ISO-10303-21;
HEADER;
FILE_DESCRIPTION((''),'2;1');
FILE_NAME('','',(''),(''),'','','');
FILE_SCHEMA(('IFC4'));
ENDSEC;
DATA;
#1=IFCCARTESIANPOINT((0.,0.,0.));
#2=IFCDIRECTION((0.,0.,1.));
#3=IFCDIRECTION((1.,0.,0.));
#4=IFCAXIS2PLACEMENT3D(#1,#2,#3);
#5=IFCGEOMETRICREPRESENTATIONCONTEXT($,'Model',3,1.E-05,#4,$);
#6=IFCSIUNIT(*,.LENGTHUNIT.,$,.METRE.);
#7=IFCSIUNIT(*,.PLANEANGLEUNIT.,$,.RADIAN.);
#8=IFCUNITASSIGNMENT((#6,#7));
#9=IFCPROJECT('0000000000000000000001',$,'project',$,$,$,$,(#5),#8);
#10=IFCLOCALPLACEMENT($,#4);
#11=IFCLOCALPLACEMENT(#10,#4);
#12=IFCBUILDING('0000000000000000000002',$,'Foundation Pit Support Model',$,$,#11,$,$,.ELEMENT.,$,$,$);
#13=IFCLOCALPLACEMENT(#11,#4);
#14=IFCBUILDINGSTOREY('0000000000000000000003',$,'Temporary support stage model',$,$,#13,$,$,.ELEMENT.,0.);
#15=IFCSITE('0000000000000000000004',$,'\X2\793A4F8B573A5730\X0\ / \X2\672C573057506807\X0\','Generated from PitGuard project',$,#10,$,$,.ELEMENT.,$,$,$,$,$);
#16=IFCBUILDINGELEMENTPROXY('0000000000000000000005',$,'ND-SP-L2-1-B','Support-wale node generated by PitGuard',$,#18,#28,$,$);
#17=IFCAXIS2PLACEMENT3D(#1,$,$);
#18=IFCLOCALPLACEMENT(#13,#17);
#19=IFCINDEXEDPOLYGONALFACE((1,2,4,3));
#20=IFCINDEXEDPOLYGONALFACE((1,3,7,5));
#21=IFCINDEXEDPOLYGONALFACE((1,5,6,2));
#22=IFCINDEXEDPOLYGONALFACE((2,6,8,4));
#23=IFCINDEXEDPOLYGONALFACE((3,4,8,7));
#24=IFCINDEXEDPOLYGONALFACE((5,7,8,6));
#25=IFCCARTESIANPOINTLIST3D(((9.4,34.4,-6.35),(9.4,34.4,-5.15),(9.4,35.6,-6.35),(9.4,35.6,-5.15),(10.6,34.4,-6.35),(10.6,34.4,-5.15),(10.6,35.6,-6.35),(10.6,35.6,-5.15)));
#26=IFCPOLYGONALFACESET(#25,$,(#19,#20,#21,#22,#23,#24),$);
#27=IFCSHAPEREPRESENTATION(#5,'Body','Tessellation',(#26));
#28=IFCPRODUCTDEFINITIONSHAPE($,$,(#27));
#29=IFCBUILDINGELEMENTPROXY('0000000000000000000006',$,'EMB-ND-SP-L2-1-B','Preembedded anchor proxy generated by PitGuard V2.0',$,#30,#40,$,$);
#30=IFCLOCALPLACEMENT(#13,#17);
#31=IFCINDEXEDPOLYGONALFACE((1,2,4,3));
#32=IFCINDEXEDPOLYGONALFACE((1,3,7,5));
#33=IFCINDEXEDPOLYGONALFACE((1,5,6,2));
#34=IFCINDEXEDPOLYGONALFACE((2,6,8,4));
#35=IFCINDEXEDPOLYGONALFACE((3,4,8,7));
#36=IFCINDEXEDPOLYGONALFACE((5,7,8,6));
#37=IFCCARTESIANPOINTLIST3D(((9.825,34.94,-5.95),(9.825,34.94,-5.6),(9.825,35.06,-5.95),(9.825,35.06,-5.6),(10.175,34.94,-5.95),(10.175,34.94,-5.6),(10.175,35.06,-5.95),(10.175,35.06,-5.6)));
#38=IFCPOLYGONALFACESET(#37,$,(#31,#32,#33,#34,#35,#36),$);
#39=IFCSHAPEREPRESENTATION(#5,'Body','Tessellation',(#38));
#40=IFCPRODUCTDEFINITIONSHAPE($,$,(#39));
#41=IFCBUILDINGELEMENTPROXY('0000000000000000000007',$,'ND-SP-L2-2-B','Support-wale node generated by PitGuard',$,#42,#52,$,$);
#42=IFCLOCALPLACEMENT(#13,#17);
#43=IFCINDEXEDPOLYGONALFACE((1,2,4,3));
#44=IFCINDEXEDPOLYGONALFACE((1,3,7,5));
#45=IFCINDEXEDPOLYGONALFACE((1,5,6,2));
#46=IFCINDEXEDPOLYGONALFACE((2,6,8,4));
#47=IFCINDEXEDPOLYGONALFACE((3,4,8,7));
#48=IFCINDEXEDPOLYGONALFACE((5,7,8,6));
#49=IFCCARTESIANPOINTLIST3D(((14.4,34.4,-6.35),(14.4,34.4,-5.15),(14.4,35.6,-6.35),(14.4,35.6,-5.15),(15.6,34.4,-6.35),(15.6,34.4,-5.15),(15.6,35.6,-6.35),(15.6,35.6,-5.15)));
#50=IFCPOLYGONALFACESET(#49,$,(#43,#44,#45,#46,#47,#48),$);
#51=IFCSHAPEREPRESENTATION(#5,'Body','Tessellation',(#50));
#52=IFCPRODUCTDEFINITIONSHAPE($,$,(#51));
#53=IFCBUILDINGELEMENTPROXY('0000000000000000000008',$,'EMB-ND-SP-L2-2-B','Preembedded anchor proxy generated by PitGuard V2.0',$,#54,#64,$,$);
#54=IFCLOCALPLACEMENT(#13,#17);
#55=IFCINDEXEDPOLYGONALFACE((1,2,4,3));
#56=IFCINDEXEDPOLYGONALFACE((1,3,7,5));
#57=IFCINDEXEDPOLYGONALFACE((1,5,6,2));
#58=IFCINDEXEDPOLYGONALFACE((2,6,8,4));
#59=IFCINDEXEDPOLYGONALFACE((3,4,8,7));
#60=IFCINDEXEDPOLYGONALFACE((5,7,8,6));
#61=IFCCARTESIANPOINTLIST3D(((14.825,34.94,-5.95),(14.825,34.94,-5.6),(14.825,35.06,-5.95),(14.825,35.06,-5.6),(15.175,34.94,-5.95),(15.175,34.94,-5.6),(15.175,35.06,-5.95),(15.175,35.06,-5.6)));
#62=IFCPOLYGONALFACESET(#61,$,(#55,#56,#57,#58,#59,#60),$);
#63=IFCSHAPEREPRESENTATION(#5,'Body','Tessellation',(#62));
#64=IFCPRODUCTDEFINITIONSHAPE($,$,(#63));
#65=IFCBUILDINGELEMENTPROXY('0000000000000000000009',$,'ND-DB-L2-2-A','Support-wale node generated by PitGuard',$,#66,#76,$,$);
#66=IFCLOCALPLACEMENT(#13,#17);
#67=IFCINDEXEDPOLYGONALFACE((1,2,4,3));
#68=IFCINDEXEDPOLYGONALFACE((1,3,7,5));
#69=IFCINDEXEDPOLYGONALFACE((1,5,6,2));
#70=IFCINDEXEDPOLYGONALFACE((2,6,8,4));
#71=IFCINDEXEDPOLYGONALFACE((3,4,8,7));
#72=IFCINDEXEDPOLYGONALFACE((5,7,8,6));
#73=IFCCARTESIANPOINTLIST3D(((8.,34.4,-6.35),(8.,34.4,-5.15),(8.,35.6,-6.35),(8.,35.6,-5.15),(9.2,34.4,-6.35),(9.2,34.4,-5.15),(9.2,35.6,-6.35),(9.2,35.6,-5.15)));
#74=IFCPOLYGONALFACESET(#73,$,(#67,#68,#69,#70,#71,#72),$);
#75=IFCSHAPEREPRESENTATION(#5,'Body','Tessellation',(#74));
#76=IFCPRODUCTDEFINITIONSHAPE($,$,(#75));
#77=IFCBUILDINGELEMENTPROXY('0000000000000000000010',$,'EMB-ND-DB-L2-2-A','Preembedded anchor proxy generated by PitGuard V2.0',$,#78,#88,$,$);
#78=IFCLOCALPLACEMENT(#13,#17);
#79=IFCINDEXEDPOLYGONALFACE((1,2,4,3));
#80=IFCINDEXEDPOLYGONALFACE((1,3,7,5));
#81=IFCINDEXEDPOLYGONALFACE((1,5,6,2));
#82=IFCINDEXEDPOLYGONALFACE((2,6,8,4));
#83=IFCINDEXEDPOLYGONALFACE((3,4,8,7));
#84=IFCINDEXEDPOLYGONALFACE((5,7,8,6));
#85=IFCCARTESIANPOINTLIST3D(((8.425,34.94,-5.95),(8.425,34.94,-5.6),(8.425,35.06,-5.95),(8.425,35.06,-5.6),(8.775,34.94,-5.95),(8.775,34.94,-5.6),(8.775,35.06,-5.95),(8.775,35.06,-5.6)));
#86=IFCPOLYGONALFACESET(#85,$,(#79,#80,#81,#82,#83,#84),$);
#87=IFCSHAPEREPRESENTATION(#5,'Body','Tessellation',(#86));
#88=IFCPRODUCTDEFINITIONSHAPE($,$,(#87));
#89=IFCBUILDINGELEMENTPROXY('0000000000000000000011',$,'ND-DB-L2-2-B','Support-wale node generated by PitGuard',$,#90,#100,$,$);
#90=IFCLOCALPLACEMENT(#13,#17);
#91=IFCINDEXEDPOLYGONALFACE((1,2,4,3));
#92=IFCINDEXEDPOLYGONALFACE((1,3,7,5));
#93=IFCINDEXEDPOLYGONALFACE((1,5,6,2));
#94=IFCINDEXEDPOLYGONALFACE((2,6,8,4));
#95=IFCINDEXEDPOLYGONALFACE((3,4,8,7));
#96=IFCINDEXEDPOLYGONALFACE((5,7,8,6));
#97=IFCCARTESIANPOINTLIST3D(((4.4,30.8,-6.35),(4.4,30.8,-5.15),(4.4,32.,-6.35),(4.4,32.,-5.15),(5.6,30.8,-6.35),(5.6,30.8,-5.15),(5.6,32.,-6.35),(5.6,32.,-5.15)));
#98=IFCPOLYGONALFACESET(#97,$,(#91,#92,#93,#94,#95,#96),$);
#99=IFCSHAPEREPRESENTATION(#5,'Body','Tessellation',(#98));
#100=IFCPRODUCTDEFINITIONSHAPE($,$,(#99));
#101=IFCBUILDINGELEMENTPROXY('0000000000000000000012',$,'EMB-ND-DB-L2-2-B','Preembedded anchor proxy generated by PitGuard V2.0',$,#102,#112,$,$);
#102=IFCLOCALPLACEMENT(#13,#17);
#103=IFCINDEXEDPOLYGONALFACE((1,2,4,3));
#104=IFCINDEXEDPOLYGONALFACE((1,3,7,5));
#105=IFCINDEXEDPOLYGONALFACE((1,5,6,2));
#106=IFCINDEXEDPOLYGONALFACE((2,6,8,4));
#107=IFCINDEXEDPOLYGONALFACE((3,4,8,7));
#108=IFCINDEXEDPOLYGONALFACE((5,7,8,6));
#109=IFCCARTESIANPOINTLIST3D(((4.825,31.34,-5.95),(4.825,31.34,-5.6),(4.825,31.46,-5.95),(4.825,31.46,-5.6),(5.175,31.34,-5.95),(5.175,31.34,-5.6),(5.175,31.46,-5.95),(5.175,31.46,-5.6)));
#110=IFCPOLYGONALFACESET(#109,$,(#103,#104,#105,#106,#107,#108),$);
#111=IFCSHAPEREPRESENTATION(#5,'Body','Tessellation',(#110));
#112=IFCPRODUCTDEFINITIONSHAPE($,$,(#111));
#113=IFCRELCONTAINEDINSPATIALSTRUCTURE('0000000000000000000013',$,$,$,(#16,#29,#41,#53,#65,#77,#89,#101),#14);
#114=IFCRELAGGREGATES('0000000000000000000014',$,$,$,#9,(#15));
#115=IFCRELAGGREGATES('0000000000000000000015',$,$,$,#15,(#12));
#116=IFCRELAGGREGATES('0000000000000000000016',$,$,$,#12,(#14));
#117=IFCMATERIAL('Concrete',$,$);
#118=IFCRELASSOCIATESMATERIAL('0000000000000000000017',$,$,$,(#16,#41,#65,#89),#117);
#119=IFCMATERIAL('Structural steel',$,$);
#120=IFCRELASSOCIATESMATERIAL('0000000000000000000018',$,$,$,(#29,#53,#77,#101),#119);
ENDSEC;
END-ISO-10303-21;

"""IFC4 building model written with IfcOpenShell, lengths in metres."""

from ifc_helpers import new_model, si_unit, frame, origin_with_axes, origin_2d, place, context, project, spatial, rectangle, extrude, material, element, save


model = new_model("IFC4")

# Units and contexts
model_context = context("Model", 3, precision=1e-05, world=origin_with_axes())
ifc_project = project(units=[si_unit("LENGTHUNIT", "METRE"), si_unit("PLANEANGLEUNIT", "RADIAN")], contexts=[model_context])

# Site, building, storey
site_placement = place(None, origin_with_axes())
site = spatial("IfcSite", under=ifc_project, at=site_placement, Name="示例场地 / 本地坐标", Description="Generated from PitGuard project", CompositionType="ELEMENT")
building_placement = place(site_placement, origin_with_axes())
building = spatial("IfcBuilding", under=site, at=building_placement, Name="Foundation Pit Support Model", CompositionType="ELEMENT")
storey_placement = place(building_placement, origin_with_axes())
storey = spatial("IfcBuildingStorey", under=building, at=storey_placement, Name="Temporary support stage model", CompositionType="ELEMENT", Elevation=0.0)

# Shared definitions
ifc_material_1 = material(Name="Concrete")

# Shared definitions
ifc_material_2 = material(Name="Structural steel")

# Building element proxies
proxy_1_placement = place(storey_placement, frame((10.0, 35.0, -6.35), z_axis=(0.0, 0.0, 1.0), x_axis=(1.0, 0.0, 0.0)))
element("IfcBuildingElementProxy", 1, at=proxy_1_placement, inside=storey, material=ifc_material_1, Name="ND-SP-L2-1-B", Description="Support-wale node generated by PitGuard", context=model_context, shape_type="SweptSolid", body=[
    extrude(rectangle(XDim=1.2, YDim=1.2, at=origin_2d()), origin_with_axes(), (0.0, 0.0, 1.0), 1.2),
])
proxy_2_placement = place(storey_placement, frame((10.0, 35.0, -5.95), z_axis=(0.0, 0.0, 1.0), x_axis=(1.0, 0.0, 0.0)))
element("IfcBuildingElementProxy", 2, at=proxy_2_placement, inside=storey, material=ifc_material_2, Name="EMB-ND-SP-L2-1-B", Description="Preembedded anchor proxy generated by PitGuard V2.0", context=model_context, shape_type="SweptSolid", body=[
    extrude(rectangle(XDim=0.35, YDim=0.12, at=origin_2d()), origin_with_axes(), (0.0, 0.0, 1.0), 0.35),
])
proxy_3_placement = place(storey_placement, frame((15.0, 35.0, -6.35), z_axis=(0.0, 0.0, 1.0), x_axis=(1.0, 0.0, 0.0)))
element("IfcBuildingElementProxy", 3, at=proxy_3_placement, inside=storey, material=ifc_material_1, Name="ND-SP-L2-2-B", Description="Support-wale node generated by PitGuard", context=model_context, shape_type="SweptSolid", body=[
    extrude(rectangle(XDim=1.2, YDim=1.2, at=origin_2d()), origin_with_axes(), (0.0, 0.0, 1.0), 1.2),
])
proxy_4_placement = place(storey_placement, frame((15.0, 35.0, -5.95), z_axis=(0.0, 0.0, 1.0), x_axis=(1.0, 0.0, 0.0)))
element("IfcBuildingElementProxy", 4, at=proxy_4_placement, inside=storey, material=ifc_material_2, Name="EMB-ND-SP-L2-2-B", Description="Preembedded anchor proxy generated by PitGuard V2.0", context=model_context, shape_type="SweptSolid", body=[
    extrude(rectangle(XDim=0.35, YDim=0.12, at=origin_2d()), origin_with_axes(), (0.0, 0.0, 1.0), 0.35),
])
proxy_5_placement = place(storey_placement, frame((8.6, 35.0, -6.35), z_axis=(0.0, 0.0, 1.0), x_axis=(1.0, 0.0, 0.0)))
element("IfcBuildingElementProxy", 5, at=proxy_5_placement, inside=storey, material=ifc_material_1, Name="ND-DB-L2-2-A", Description="Support-wale node generated by PitGuard", context=model_context, shape_type="SweptSolid", body=[
    extrude(rectangle(XDim=1.2, YDim=1.2, at=origin_2d()), origin_with_axes(), (0.0, 0.0, 1.0), 1.2),
])
proxy_6_placement = place(storey_placement, frame((8.6, 35.0, -5.95), z_axis=(0.0, 0.0, 1.0), x_axis=(1.0, 0.0, 0.0)))
element("IfcBuildingElementProxy", 6, at=proxy_6_placement, inside=storey, material=ifc_material_2, Name="EMB-ND-DB-L2-2-A", Description="Preembedded anchor proxy generated by PitGuard V2.0", context=model_context, shape_type="SweptSolid", body=[
    extrude(rectangle(XDim=0.35, YDim=0.12, at=origin_2d()), origin_with_axes(), (0.0, 0.0, 1.0), 0.35),
])
proxy_7_placement = place(storey_placement, frame((5.0, 31.4, -6.35), z_axis=(0.0, 0.0, 1.0), x_axis=(1.0, 0.0, 0.0)))
element("IfcBuildingElementProxy", 7, at=proxy_7_placement, inside=storey, material=ifc_material_1, Name="ND-DB-L2-2-B", Description="Support-wale node generated by PitGuard", context=model_context, shape_type="SweptSolid", body=[
    extrude(rectangle(XDim=1.2, YDim=1.2, at=origin_2d()), origin_with_axes(), (0.0, 0.0, 1.0), 1.2),
])
proxy_8_placement = place(storey_placement, frame((5.0, 31.4, -5.95), z_axis=(0.0, 0.0, 1.0), x_axis=(1.0, 0.0, 0.0)))
element("IfcBuildingElementProxy", 8, at=proxy_8_placement, inside=storey, material=ifc_material_2, Name="EMB-ND-DB-L2-2-B", Description="Preembedded anchor proxy generated by PitGuard V2.0", context=model_context, shape_type="SweptSolid", body=[
    extrude(rectangle(XDim=0.35, YDim=0.12, at=origin_2d()), origin_with_axes(), (0.0, 0.0, 1.0), 0.35),
])

save(model, "model.ifc")
